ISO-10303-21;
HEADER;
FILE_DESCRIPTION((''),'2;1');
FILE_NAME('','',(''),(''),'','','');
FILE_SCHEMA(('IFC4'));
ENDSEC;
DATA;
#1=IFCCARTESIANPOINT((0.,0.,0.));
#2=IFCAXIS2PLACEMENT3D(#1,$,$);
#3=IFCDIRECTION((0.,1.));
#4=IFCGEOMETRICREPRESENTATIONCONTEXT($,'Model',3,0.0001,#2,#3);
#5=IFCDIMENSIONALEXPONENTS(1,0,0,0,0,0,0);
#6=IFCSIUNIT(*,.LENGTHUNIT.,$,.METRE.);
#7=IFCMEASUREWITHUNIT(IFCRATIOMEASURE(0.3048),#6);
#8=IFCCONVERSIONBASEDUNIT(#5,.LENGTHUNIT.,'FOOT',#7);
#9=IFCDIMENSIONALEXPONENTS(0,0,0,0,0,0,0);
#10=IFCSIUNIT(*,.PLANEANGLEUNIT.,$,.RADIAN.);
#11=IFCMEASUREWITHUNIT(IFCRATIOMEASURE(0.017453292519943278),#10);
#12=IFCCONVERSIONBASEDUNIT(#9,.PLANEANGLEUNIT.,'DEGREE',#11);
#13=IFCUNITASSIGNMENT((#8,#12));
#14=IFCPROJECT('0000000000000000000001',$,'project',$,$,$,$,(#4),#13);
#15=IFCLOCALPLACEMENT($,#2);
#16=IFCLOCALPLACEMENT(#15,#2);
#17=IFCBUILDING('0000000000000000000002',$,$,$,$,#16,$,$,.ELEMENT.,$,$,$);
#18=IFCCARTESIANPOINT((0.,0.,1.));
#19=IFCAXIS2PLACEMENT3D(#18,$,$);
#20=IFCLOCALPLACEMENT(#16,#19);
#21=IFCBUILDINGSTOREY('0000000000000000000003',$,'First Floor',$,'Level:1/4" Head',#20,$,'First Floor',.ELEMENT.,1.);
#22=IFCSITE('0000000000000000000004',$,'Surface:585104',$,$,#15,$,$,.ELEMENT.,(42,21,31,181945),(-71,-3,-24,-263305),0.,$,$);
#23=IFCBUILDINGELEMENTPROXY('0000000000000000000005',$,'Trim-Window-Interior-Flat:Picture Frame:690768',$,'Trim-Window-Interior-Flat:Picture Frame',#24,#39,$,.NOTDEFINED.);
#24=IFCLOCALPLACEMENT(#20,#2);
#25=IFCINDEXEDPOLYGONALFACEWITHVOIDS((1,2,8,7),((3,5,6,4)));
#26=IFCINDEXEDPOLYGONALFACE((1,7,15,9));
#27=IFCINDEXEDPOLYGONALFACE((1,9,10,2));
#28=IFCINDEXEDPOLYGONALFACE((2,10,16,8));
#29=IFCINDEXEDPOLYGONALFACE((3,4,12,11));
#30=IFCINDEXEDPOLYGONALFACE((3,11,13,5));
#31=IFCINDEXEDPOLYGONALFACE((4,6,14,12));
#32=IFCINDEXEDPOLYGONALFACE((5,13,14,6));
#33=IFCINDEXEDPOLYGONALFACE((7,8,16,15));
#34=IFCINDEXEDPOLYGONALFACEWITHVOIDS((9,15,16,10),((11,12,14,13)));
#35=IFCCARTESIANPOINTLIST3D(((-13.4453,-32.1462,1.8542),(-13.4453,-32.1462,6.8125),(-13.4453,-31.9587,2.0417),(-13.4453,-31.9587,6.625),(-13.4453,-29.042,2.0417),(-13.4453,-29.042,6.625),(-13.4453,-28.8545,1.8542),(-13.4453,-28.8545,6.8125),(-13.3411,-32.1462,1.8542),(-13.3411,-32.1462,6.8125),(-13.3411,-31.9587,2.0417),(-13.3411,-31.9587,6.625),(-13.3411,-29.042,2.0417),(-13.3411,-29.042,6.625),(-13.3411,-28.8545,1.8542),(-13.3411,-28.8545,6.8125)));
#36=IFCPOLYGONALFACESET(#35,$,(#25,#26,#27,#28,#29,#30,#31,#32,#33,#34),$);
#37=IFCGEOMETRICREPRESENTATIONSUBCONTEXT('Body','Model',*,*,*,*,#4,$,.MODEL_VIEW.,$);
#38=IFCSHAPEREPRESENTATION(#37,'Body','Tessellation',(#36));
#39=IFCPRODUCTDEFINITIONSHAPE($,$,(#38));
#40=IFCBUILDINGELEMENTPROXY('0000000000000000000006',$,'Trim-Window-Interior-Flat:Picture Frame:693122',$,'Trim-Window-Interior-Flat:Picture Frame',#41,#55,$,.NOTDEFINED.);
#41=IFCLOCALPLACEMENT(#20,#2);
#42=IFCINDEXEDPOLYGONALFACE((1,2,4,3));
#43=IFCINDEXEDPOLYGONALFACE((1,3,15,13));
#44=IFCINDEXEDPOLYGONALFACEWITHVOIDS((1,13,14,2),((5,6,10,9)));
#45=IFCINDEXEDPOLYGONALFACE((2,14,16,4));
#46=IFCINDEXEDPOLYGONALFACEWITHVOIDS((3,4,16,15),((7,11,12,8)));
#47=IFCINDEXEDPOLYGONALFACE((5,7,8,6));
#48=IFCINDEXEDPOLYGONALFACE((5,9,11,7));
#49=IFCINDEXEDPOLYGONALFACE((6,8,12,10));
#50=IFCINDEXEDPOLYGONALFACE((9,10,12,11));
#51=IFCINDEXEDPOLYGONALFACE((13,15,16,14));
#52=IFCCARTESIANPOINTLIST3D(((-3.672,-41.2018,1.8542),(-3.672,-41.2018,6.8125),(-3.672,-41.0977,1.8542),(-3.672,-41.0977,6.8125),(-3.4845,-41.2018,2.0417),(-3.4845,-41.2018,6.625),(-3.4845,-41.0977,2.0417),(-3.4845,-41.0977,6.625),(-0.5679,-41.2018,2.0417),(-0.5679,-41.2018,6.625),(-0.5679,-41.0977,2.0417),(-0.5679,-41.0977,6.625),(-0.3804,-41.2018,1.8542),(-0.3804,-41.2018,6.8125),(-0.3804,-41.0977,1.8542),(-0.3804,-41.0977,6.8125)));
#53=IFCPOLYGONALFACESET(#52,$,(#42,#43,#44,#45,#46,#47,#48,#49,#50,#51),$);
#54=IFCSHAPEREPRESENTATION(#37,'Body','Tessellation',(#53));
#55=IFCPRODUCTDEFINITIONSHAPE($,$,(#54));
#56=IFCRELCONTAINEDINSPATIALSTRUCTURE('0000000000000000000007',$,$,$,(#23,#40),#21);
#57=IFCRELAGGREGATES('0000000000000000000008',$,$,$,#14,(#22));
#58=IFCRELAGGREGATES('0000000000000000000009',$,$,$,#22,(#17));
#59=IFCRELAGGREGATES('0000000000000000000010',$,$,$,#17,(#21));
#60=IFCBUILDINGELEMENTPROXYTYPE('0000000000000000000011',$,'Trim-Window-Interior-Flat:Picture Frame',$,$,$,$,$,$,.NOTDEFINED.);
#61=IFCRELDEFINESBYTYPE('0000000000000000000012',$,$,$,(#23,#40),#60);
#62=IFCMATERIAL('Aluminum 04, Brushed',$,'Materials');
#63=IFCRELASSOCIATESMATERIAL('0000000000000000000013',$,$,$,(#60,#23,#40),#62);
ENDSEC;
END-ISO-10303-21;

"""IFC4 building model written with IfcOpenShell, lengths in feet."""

from ifc_helpers import new_model, entity, si_unit, converted_unit, direction, frame, origin, place, context, subcontext, project, spatial, indexed_curve, outline, extrude, source, transform, mapped, material, type_object, type_shapes, element, save


model = new_model("IFC4")

# Units and contexts
model_context = context("Model", 3, precision=0.0001, world=origin(), true_north=direction((0.0, 1.0)))
body_context = subcontext(model_context, "Body", "Model", "MODEL_VIEW")
ifc_project = project(units=[converted_unit("LENGTHUNIT", "FOOT", entity("IfcRatioMeasure", 0.3048), si_unit("LENGTHUNIT", "METRE"), dimensions=[1, 0, 0, 0, 0, 0, 0]), converted_unit("PLANEANGLEUNIT", "DEGREE", entity("IfcRatioMeasure", 0.017453292519943278), si_unit("PLANEANGLEUNIT", "RADIAN"), dimensions=[0, 0, 0, 0, 0, 0, 0])], contexts=[model_context])

# Site, building, storey
site_placement = place(None, origin())
site = spatial("IfcSite", under=ifc_project, at=site_placement, Name="Surface:585104", CompositionType="ELEMENT", RefLatitude=(42, 21, 31, 181945), RefLongitude=(-71, -3, -24, -263305), RefElevation=0.0)
building_placement = place(site_placement, origin())
building = spatial("IfcBuilding", under=site, at=building_placement, CompositionType="ELEMENT")
storey_placement = place(building_placement, frame((0.0, 0.0, 1.0)))
storey = spatial("IfcBuildingStorey", under=building, at=storey_placement, Name="First Floor", ObjectType="Level:1/4\" Head", LongName="First Floor", CompositionType="ELEMENT", Elevation=1.0)

# Shared definitions
ifc_material_1 = material(Name="Aluminum 04, Brushed", Category="Materials")

# Building element proxies
building_element_proxy_type_1 = type_object("IfcBuildingElementProxyType", Name="Trim-Window-Interior-Flat:Picture Frame", PredefinedType="NOTDEFINED", material=ifc_material_1)
shared_shape_1 = source(origin(), body_context, "Body", "SweptSolid", [
    extrude(outline(indexed_curve([(-1.6458, -2.4792), (1.6458, -2.4792), (1.6458, 2.4792), (-1.6458, 2.4792), (-1.6458, -2.4792)], self_intersect=False), holes=[indexed_curve([(-1.4583, -2.2917), (-1.4583, 2.2917), (1.4583, 2.2917), (1.4583, -2.2917), (-1.4583, -2.2917)], self_intersect=False)]), frame((0.0, -2.3333, 0.0), z_axis=(0.0, 0.0, 1.0), x_axis=(-1.0, 0.0, 0.0)), (0.0, 0.0, 1.0), 0.1042),
])
type_shapes(building_element_proxy_type_1, [shared_shape_1])
for number, where, z_axis, x_axis, name in (
    (1, (-13.3411, -30.5004, 6.6667), (-1.0, 0.0, 0.0), (0.0, -1.0, 0.0), "Trim-Window-Interior-Flat:Picture Frame:690768"),
    (2, (-2.0262, -41.0977, 6.6667), (0.0, -1.0, 0.0), (1.0, 0.0, 0.0), "Trim-Window-Interior-Flat:Picture Frame:693122"),
):
    element("IfcBuildingElementProxy", number, at=place(storey_placement, frame(where, z_axis=z_axis, x_axis=x_axis)), inside=storey, type_object=building_element_proxy_type_1, material=ifc_material_1, Name=name, ObjectType="Trim-Window-Interior-Flat:Picture Frame", PredefinedType="NOTDEFINED", context=body_context, shape_type="MappedRepresentation", body=[
        mapped(shared_shape_1, transform((0.0, 0.0, 0.0), scale=1.0)),
    ])

save(model, "model.ifc")
